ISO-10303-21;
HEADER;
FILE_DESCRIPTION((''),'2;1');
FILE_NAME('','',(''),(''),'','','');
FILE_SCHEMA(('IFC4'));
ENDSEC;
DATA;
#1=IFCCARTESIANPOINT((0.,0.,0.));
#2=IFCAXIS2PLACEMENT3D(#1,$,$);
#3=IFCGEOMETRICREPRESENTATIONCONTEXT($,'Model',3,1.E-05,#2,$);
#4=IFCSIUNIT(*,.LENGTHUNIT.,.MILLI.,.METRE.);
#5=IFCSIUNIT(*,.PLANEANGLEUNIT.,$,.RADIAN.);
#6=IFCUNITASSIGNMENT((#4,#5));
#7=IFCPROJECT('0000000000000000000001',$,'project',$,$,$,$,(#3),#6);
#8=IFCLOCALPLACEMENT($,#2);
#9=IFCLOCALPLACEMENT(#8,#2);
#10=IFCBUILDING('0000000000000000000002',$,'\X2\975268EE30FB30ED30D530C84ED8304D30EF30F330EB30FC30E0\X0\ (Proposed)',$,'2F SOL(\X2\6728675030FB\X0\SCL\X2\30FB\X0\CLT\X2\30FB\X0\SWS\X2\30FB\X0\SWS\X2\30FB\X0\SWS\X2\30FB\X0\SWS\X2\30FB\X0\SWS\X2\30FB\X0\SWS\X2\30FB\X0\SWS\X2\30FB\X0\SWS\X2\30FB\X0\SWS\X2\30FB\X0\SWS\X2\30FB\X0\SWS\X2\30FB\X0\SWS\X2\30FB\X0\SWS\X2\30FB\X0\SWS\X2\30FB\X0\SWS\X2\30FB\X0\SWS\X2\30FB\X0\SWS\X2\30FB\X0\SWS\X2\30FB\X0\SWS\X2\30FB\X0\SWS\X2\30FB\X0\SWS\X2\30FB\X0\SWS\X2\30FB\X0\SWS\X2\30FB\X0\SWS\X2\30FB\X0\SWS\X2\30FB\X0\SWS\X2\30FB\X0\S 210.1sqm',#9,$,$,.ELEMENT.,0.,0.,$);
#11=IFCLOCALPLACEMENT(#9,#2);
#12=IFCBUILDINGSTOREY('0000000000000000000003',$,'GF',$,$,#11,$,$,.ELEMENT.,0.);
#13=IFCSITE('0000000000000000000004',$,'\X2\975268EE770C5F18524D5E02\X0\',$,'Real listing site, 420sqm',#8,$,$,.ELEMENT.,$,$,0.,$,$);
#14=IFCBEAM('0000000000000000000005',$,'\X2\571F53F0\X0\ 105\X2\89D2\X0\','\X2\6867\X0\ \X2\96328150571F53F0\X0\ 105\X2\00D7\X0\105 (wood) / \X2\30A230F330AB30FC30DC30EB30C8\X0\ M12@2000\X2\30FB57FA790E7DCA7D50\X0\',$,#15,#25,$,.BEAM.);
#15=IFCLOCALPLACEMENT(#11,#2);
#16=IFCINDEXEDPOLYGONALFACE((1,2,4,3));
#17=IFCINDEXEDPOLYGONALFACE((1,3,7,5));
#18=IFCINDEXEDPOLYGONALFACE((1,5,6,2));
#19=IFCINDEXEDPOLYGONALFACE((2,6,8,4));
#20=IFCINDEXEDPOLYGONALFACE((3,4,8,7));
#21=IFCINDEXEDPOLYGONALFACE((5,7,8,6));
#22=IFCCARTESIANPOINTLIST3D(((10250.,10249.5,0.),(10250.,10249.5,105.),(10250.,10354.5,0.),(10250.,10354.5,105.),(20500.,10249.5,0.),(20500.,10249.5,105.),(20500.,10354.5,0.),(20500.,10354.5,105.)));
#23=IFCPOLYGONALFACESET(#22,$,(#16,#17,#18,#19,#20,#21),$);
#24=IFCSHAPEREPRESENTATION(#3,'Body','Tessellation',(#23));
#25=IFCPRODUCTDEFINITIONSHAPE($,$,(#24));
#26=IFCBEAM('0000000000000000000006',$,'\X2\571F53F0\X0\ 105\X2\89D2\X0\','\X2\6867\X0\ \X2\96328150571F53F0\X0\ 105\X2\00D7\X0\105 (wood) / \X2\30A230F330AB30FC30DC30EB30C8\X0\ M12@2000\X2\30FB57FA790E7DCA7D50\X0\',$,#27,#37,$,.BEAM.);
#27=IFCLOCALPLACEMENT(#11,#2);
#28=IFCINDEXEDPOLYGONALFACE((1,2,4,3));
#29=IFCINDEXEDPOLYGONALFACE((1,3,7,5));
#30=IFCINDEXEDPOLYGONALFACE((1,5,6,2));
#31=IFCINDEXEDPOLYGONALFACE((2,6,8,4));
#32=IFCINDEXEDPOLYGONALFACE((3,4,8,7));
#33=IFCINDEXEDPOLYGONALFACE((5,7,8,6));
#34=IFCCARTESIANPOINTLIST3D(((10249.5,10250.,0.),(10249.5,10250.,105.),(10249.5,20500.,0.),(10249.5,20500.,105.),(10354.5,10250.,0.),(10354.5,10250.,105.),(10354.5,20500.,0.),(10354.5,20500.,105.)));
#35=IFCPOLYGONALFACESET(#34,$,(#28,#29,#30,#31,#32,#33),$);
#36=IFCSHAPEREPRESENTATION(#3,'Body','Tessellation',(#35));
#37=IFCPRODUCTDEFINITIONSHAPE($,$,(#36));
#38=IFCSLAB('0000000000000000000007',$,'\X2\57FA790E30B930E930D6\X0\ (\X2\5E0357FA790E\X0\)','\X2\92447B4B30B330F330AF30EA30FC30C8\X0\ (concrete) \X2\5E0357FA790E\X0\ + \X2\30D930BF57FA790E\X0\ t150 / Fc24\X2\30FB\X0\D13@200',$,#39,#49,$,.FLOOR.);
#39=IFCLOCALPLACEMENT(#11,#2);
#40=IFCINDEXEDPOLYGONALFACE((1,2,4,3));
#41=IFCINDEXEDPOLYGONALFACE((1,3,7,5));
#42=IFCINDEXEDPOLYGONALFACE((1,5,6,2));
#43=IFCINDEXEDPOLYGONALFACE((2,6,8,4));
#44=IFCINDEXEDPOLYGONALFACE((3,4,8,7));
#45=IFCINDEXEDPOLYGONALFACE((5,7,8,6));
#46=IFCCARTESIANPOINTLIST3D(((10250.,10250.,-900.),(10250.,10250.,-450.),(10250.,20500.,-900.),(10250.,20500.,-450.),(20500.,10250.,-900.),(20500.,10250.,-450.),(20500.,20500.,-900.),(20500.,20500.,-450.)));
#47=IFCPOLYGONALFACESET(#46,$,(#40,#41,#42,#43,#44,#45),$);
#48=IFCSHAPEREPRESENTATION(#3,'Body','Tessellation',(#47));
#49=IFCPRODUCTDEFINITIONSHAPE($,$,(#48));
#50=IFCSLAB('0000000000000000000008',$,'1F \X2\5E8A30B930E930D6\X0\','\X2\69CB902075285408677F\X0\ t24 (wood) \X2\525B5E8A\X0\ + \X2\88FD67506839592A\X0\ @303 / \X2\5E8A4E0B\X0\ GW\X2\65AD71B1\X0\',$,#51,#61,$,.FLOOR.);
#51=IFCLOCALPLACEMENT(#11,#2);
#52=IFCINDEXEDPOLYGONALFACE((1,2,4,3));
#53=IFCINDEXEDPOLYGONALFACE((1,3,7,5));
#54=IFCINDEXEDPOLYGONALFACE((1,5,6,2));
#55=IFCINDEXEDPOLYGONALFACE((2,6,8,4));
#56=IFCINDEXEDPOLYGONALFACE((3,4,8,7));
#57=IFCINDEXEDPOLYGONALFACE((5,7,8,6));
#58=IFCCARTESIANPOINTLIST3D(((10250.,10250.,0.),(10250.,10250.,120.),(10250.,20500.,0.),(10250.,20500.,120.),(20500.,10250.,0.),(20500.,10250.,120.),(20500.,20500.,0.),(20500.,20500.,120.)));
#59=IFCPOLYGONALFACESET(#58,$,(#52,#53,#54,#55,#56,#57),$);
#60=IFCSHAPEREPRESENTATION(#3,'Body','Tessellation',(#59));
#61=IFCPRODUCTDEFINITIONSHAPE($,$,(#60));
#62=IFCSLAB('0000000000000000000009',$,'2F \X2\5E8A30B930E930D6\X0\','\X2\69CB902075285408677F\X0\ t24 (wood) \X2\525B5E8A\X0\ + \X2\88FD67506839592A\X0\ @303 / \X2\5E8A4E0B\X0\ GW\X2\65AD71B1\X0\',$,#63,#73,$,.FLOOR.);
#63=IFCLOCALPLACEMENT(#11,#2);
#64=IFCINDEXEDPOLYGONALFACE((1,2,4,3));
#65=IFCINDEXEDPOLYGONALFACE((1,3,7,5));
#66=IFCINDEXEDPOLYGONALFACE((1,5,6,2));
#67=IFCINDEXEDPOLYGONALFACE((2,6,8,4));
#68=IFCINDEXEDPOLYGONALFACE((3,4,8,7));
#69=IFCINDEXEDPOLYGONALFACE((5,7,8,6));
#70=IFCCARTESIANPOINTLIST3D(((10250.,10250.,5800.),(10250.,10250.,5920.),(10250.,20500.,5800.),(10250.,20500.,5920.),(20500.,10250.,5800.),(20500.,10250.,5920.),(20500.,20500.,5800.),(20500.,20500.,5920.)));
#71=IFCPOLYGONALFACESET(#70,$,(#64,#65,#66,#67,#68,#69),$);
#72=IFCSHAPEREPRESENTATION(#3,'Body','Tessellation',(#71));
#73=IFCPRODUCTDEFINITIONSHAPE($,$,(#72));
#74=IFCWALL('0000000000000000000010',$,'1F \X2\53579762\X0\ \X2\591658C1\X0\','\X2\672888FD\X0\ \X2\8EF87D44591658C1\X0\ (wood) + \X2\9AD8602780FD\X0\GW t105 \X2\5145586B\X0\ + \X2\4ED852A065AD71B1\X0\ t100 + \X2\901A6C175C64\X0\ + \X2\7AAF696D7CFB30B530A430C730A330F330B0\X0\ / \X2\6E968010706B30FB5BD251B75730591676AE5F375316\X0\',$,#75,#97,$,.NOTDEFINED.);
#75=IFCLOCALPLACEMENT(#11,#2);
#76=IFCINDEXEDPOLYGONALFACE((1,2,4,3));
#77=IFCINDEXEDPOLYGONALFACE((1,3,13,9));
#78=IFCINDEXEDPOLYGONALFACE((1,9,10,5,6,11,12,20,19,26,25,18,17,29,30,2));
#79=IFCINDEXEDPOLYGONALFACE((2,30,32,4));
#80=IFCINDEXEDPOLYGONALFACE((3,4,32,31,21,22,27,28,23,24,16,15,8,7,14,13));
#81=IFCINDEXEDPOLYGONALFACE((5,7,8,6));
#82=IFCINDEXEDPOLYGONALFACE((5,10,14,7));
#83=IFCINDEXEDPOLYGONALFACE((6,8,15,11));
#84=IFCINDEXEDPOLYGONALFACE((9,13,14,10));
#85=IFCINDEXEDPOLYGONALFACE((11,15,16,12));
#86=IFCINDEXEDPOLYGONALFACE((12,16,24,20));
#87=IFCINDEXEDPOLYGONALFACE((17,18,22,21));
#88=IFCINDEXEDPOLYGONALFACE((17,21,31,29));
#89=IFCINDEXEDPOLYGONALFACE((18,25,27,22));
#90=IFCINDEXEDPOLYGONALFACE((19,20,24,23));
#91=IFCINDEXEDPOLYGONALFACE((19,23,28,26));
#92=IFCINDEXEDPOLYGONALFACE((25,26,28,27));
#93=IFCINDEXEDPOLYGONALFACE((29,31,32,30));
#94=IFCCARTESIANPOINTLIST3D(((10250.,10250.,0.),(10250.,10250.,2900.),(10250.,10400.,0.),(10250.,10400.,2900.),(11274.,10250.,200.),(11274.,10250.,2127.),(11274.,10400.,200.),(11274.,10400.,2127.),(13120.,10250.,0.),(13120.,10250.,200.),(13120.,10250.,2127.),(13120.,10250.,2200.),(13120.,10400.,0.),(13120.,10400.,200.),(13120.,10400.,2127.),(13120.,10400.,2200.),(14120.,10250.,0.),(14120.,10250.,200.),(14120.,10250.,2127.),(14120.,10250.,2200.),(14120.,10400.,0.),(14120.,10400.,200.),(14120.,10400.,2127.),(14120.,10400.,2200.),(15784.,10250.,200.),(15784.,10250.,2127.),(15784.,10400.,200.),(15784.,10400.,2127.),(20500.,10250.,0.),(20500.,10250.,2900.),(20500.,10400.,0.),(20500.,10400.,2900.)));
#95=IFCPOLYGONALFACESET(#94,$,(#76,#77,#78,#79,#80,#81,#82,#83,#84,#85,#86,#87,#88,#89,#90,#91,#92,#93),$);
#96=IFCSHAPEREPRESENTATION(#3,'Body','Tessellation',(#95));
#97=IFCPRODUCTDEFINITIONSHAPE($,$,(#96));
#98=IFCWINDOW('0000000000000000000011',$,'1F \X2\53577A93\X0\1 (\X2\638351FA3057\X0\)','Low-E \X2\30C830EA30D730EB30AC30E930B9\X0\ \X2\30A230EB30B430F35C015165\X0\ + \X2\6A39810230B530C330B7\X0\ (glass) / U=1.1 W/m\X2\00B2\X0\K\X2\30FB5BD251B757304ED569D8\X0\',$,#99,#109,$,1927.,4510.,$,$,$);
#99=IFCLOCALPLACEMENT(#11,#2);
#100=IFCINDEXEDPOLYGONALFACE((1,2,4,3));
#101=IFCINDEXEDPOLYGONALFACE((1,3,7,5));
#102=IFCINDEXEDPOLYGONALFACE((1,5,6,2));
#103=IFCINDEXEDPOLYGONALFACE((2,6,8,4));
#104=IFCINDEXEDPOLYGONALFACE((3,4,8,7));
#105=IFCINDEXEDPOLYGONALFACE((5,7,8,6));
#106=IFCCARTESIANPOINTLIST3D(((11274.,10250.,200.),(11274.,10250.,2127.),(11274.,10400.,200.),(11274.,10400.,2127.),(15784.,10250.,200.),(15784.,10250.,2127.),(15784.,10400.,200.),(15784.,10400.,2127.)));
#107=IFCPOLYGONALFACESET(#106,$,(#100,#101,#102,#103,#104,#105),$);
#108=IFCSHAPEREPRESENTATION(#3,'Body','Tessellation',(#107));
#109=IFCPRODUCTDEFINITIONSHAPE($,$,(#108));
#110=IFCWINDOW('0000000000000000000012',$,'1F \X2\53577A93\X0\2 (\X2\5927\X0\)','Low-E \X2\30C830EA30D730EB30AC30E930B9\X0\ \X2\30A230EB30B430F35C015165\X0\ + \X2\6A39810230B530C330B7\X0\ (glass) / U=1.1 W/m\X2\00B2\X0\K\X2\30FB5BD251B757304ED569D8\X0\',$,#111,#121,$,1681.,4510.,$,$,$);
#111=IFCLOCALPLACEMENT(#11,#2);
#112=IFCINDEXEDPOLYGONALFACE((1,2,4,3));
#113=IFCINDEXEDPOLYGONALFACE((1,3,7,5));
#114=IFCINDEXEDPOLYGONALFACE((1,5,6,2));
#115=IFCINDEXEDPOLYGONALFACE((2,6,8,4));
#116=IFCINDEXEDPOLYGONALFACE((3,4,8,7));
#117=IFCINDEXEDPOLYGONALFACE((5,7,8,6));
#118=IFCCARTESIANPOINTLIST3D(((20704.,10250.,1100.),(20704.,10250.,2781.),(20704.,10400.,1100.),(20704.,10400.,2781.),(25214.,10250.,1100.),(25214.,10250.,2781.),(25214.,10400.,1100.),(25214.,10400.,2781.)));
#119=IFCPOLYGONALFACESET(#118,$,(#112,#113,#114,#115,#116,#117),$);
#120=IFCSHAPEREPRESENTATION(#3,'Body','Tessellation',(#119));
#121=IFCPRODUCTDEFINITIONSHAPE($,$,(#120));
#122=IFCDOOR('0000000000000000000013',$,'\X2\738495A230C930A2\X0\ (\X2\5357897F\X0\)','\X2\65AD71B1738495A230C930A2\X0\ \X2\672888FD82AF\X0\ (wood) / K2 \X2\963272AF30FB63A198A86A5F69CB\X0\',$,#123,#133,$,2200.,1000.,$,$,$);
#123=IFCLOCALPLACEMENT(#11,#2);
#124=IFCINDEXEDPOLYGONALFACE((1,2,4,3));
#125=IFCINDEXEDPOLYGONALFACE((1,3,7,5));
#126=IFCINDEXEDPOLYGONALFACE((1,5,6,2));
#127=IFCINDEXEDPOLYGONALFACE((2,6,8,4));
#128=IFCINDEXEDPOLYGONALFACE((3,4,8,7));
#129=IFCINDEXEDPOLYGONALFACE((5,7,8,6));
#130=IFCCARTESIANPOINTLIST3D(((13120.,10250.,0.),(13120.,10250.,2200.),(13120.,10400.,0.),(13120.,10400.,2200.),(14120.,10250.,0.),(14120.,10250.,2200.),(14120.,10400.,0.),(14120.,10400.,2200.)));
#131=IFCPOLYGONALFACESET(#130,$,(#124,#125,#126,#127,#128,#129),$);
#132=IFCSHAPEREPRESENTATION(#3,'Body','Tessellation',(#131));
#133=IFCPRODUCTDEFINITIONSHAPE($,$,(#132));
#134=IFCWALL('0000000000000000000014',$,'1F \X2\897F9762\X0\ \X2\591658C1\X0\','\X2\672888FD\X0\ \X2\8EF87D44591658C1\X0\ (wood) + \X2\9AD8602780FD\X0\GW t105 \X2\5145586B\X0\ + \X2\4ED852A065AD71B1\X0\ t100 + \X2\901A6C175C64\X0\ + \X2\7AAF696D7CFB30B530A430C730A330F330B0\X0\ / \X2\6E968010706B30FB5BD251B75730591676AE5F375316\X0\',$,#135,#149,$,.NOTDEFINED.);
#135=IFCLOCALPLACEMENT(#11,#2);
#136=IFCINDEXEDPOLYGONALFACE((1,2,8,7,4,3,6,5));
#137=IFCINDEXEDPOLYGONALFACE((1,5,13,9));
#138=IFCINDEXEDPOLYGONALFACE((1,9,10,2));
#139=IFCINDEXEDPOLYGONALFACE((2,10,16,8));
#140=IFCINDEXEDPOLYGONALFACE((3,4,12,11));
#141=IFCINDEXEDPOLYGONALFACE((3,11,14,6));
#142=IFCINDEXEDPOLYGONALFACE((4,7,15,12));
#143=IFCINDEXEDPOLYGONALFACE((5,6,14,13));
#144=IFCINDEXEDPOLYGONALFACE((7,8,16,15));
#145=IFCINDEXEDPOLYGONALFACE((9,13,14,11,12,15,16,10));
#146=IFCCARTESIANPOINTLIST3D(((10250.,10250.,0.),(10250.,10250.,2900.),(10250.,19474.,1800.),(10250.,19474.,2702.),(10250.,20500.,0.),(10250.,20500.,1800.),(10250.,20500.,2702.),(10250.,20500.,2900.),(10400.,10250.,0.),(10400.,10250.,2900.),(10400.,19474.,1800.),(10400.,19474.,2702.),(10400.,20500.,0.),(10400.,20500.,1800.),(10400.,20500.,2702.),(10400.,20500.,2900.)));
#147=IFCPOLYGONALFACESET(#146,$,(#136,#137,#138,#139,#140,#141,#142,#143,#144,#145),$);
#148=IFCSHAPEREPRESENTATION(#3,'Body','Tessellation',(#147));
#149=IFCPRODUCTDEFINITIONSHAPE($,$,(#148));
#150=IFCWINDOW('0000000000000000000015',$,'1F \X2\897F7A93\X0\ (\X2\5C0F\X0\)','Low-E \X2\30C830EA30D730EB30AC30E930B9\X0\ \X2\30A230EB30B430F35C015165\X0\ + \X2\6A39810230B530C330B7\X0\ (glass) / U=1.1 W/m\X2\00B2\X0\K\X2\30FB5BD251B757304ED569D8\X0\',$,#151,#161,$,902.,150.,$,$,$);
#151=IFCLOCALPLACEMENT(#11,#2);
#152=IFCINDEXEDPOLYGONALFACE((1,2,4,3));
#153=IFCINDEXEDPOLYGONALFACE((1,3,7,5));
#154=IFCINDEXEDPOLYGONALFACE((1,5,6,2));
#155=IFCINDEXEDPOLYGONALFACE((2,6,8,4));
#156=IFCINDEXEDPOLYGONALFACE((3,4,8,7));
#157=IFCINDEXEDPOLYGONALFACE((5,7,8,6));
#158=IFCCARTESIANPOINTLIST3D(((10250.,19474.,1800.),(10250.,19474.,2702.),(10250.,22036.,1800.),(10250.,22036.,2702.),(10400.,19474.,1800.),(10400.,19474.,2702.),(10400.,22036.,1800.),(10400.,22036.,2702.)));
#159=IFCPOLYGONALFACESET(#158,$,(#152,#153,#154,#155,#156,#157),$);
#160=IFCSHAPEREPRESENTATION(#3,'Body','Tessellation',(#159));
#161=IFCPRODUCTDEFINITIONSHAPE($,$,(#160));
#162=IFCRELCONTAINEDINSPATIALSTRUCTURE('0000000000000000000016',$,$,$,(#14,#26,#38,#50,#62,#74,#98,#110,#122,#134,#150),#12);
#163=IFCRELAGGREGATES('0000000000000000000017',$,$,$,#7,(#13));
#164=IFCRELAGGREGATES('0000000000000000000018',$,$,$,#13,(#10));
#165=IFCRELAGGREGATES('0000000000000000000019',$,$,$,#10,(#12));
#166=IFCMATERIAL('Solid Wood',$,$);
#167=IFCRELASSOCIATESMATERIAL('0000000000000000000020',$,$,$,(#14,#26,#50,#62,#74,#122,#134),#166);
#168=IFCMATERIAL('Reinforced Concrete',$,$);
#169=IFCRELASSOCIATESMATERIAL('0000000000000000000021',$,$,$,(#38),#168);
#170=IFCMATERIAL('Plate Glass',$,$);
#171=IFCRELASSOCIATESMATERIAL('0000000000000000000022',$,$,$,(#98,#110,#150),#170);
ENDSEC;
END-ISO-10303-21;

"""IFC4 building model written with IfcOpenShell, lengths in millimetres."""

from ifc_helpers import new_model, si_unit, frame, frame_2d, origin, place, context, project, spatial, rectangle, extrude, material, element, fill, save


model = new_model("IFC4")

# Units and contexts
model_context = context("Model", 3, precision=1e-05, world=origin())
ifc_project = project(units=[si_unit("LENGTHUNIT", "METRE", prefix="MILLI"), si_unit("PLANEANGLEUNIT", "RADIAN")], contexts=[model_context])

# Site, building, storey
site_placement = place(None, origin())
site = spatial("IfcSite", under=ifc_project, at=site_placement, Name="青森県弘前市", ObjectType="Real listing site, 420sqm", CompositionType="ELEMENT", RefElevation=0.0)
building_placement = place(site_placement, origin())
building = spatial("IfcBuilding", under=site, at=building_placement, Name="青森・ロフト付きワンルーム (Proposed)", ObjectType="2F SOL(木材・SCL・CLT・SWS・SWS・SWS・SWS・SWS・SWS・SWS・SWS・SWS・SWS・SWS・SWS・SWS・SWS・SWS・SWS・SWS・SWS・SWS・SWS・SWS・SWS・SWS・SWS・SWS・SWS・S 210.1sqm", CompositionType="ELEMENT", ElevationOfRefHeight=0.0, ElevationOfTerrain=0.0)
storey_placement = place(building_placement, origin())
storey = spatial("IfcBuildingStorey", under=building, at=storey_placement, Name="GF", CompositionType="ELEMENT", Elevation=0.0)

# Shared definitions
ifc_material_1 = material(Name="Solid Wood")

# Beams
beam_1_placement = place(storey_placement, frame((5125.0, 5125.0, 0.0)))
element("IfcBeam", 1, at=beam_1_placement, inside=storey, material=ifc_material_1, Name="土台 105角", Description="桧 防腐土台 105×105 (wood) / アンカーボルト M12@2000・基礎緊結", PredefinedType="BEAM", context=model_context, shape_type="SweptSolid", body=[
    extrude(rectangle(XDim=10250.0, YDim=105.0, at=frame_2d((5125.0, 52.0))), frame((5125.0, 5125.0, 0.0)), (0.0, 0.0, 1.0), 105.0),
])
beam_2_placement = place(storey_placement, frame((5125.0, 5125.0, 0.0)))
element("IfcBeam", 2, at=beam_2_placement, inside=storey, material=ifc_material_1, Name="土台 105角", Description="桧 防腐土台 105×105 (wood) / アンカーボルト M12@2000・基礎緊結", PredefinedType="BEAM", context=model_context, shape_type="SweptSolid", body=[
    extrude(rectangle(XDim=105.0, YDim=10250.0, at=frame_2d((52.0, 5125.0))), frame((5125.0, 5125.0, 0.0)), (0.0, 0.0, 1.0), 105.0),
])

# Slabs
ifc_material_2 = material(Name="Reinforced Concrete")
slab_1_placement = place(storey_placement, frame((5125.0, 5125.0, -450.0)))
element("IfcSlab", 3, at=slab_1_placement, inside=storey, material=ifc_material_2, Name="基礎スラブ (布基礎)", Description="鉄筋コンクリート (concrete) 布基礎 + ベタ基礎 t150 / Fc24・D13@200", PredefinedType="FLOOR", context=model_context, shape_type="SweptSolid", body=[
    extrude(rectangle(XDim=10250.0, YDim=10250.0, at=frame_2d((5125.0, 5125.0))), frame((5125.0, 5125.0, -450.0)), (0.0, 0.0, 1.0), 450.0),
])
slab_2_placement = place(storey_placement, frame((5125.0, 5125.0, 0.0)))
element("IfcSlab", 4, at=slab_2_placement, inside=storey, material=ifc_material_1, Name="1F 床スラブ", Description="構造用合板 t24 (wood) 剛床 + 製材根太 @303 / 床下 GW断熱", PredefinedType="FLOOR", context=model_context, shape_type="SweptSolid", body=[
    extrude(rectangle(XDim=10250.0, YDim=10250.0, at=frame_2d((5125.0, 5125.0))), frame((5125.0, 5125.0, 0.0)), (0.0, 0.0, 1.0), 120.0),
])
slab_3_placement = place(storey_placement, frame((5125.0, 5125.0, 2900.0)))
element("IfcSlab", 5, at=slab_3_placement, inside=storey, material=ifc_material_1, Name="2F 床スラブ", Description="構造用合板 t24 (wood) 剛床 + 製材根太 @303 / 床下 GW断熱", PredefinedType="FLOOR", context=model_context, shape_type="SweptSolid", body=[
    extrude(rectangle(XDim=10250.0, YDim=10250.0, at=frame_2d((5125.0, 5125.0))), frame((5125.0, 5125.0, 2900.0)), (0.0, 0.0, 1.0), 120.0),
])

# Wall, openings, windows, door
wall_1_placement = place(storey_placement, frame((5125.0, 5125.0, 0.0)))
wall_1 = element("IfcWall", 6, at=wall_1_placement, inside=storey, material=ifc_material_1, Name="1F 南面 外壁", Description="木製 軸組外壁 (wood) + 高性能GW t105 充填 + 付加断熱 t100 + 通気層 + 窯業系サイディング / 準耐火・寒冷地外皮強化", PredefinedType="NOTDEFINED", context=model_context, shape_type="SweptSolid", body=[
    extrude(rectangle(XDim=10250.0, YDim=150.0, at=frame_2d((5125.0, 75.0))), frame((5125.0, 5125.0, 0.0)), (0.0, 0.0, 1.0), 2900.0),
])
opening_1_placement = place(storey_placement, frame((5637.0, 5125.0, 100.0)))
opening_1 = element("IfcOpeningElement", 7, at=opening_1_placement, cuts=wall_1, PredefinedType="NOTDEFINED", context=model_context, shape_type="SweptSolid", body=[
    extrude(rectangle(XDim=4510.0, YDim=150.0, at=frame_2d((2255.0, 75.0))), frame((5637.0, 5125.0, 100.0)), (0.0, 0.0, 1.0), 1927.0),
])
opening_2_placement = place(storey_placement, frame((10352.0, 5125.0, 550.0)))
opening_2 = element("IfcOpeningElement", 8, at=opening_2_placement, cuts=wall_1, PredefinedType="NOTDEFINED", context=model_context, shape_type="SweptSolid", body=[
    extrude(rectangle(XDim=4510.0, YDim=150.0, at=frame_2d((2255.0, 75.0))), frame((10352.0, 5125.0, 550.0)), (0.0, 0.0, 1.0), 1681.0),
])
opening_3_placement = place(storey_placement, frame((6560.0, 5125.0, 0.0)))
opening_3 = element("IfcOpeningElement", 9, at=opening_3_placement, cuts=wall_1, PredefinedType="NOTDEFINED", context=model_context, shape_type="SweptSolid", body=[
    extrude(rectangle(XDim=1000.0, YDim=150.0, at=frame_2d((500.0, 75.0))), frame((6560.0, 5125.0, 0.0)), (0.0, 0.0, 1.0), 2200.0),
])
ifc_material_3 = material(Name="Plate Glass")
window_1_placement = place(storey_placement, frame((5637.0, 5125.0, 100.0)))
window_1 = element("IfcWindow", 10, at=window_1_placement, inside=storey, material=ifc_material_3, Name="1F 南窓1 (掃出し)", Description="Low-E トリプルガラス アルゴン封入 + 樹脂サッシ (glass) / U=1.1 W/m²K・寒冷地仕様", OverallHeight=1927.0, OverallWidth=4510.0, context=model_context, shape_type="SweptSolid", body=[
    extrude(rectangle(XDim=4510.0, YDim=150.0, at=frame_2d((2255.0, 75.0))), frame((5637.0, 5125.0, 100.0)), (0.0, 0.0, 1.0), 1927.0),
])
fill(opening_1, window_1)
window_2_placement = place(storey_placement, frame((10352.0, 5125.0, 550.0)))
window_2 = element("IfcWindow", 11, at=window_2_placement, inside=storey, material=ifc_material_3, Name="1F 南窓2 (大)", Description="Low-E トリプルガラス アルゴン封入 + 樹脂サッシ (glass) / U=1.1 W/m²K・寒冷地仕様", OverallHeight=1681.0, OverallWidth=4510.0, context=model_context, shape_type="SweptSolid", body=[
    extrude(rectangle(XDim=4510.0, YDim=150.0, at=frame_2d((2255.0, 75.0))), frame((10352.0, 5125.0, 550.0)), (0.0, 0.0, 1.0), 1681.0),
])
fill(opening_2, window_2)
door_placement = place(storey_placement, frame((6560.0, 5125.0, 0.0)))
door = element("IfcDoor", 12, at=door_placement, inside=storey, material=ifc_material_1, Name="玄関ドア (南西)", Description="断熱玄関ドア 木製芯 (wood) / K2 防犯・採風機構", OverallHeight=2200.0, OverallWidth=1000.0, context=model_context, shape_type="SweptSolid", body=[
    extrude(rectangle(XDim=1000.0, YDim=150.0, at=frame_2d((500.0, 75.0))), frame((6560.0, 5125.0, 0.0)), (0.0, 0.0, 1.0), 2200.0),
])
fill(opening_3, door)

# Wall, opening, window
wall_2_placement = place(storey_placement, frame((5125.0, 5125.0, 0.0)))
wall_2 = element("IfcWall", 13, at=wall_2_placement, inside=storey, material=ifc_material_1, Name="1F 西面 外壁", Description="木製 軸組外壁 (wood) + 高性能GW t105 充填 + 付加断熱 t100 + 通気層 + 窯業系サイディング / 準耐火・寒冷地外皮強化", PredefinedType="NOTDEFINED", context=model_context, shape_type="SweptSolid", body=[
    extrude(rectangle(XDim=150.0, YDim=10250.0, at=frame_2d((75.0, 5125.0))), frame((5125.0, 5125.0, 0.0)), (0.0, 0.0, 1.0), 2900.0),
])
opening_4_placement = place(storey_placement, frame((5125.0, 9737.0, 900.0)))
opening_4 = element("IfcOpeningElement", 14, at=opening_4_placement, cuts=wall_2, PredefinedType="NOTDEFINED", context=model_context, shape_type="SweptSolid", body=[
    extrude(rectangle(XDim=150.0, YDim=2562.0, at=frame_2d((75.0, 1281.0))), frame((5125.0, 9737.0, 900.0)), (0.0, 0.0, 1.0), 902.0),
])
window_3_placement = place(storey_placement, frame((5125.0, 9737.0, 900.0)))
window_3 = element("IfcWindow", 15, at=window_3_placement, inside=storey, material=ifc_material_3, Name="1F 西窓 (小)", Description="Low-E トリプルガラス アルゴン封入 + 樹脂サッシ (glass) / U=1.1 W/m²K・寒冷地仕様", OverallHeight=902.0, OverallWidth=150.0, context=model_context, shape_type="SweptSolid", body=[
    extrude(rectangle(XDim=150.0, YDim=2562.0, at=frame_2d((75.0, 1281.0))), frame((5125.0, 9737.0, 900.0)), (0.0, 0.0, 1.0), 902.0),
])
fill(opening_4, window_3)

save(model, "model.ifc")
